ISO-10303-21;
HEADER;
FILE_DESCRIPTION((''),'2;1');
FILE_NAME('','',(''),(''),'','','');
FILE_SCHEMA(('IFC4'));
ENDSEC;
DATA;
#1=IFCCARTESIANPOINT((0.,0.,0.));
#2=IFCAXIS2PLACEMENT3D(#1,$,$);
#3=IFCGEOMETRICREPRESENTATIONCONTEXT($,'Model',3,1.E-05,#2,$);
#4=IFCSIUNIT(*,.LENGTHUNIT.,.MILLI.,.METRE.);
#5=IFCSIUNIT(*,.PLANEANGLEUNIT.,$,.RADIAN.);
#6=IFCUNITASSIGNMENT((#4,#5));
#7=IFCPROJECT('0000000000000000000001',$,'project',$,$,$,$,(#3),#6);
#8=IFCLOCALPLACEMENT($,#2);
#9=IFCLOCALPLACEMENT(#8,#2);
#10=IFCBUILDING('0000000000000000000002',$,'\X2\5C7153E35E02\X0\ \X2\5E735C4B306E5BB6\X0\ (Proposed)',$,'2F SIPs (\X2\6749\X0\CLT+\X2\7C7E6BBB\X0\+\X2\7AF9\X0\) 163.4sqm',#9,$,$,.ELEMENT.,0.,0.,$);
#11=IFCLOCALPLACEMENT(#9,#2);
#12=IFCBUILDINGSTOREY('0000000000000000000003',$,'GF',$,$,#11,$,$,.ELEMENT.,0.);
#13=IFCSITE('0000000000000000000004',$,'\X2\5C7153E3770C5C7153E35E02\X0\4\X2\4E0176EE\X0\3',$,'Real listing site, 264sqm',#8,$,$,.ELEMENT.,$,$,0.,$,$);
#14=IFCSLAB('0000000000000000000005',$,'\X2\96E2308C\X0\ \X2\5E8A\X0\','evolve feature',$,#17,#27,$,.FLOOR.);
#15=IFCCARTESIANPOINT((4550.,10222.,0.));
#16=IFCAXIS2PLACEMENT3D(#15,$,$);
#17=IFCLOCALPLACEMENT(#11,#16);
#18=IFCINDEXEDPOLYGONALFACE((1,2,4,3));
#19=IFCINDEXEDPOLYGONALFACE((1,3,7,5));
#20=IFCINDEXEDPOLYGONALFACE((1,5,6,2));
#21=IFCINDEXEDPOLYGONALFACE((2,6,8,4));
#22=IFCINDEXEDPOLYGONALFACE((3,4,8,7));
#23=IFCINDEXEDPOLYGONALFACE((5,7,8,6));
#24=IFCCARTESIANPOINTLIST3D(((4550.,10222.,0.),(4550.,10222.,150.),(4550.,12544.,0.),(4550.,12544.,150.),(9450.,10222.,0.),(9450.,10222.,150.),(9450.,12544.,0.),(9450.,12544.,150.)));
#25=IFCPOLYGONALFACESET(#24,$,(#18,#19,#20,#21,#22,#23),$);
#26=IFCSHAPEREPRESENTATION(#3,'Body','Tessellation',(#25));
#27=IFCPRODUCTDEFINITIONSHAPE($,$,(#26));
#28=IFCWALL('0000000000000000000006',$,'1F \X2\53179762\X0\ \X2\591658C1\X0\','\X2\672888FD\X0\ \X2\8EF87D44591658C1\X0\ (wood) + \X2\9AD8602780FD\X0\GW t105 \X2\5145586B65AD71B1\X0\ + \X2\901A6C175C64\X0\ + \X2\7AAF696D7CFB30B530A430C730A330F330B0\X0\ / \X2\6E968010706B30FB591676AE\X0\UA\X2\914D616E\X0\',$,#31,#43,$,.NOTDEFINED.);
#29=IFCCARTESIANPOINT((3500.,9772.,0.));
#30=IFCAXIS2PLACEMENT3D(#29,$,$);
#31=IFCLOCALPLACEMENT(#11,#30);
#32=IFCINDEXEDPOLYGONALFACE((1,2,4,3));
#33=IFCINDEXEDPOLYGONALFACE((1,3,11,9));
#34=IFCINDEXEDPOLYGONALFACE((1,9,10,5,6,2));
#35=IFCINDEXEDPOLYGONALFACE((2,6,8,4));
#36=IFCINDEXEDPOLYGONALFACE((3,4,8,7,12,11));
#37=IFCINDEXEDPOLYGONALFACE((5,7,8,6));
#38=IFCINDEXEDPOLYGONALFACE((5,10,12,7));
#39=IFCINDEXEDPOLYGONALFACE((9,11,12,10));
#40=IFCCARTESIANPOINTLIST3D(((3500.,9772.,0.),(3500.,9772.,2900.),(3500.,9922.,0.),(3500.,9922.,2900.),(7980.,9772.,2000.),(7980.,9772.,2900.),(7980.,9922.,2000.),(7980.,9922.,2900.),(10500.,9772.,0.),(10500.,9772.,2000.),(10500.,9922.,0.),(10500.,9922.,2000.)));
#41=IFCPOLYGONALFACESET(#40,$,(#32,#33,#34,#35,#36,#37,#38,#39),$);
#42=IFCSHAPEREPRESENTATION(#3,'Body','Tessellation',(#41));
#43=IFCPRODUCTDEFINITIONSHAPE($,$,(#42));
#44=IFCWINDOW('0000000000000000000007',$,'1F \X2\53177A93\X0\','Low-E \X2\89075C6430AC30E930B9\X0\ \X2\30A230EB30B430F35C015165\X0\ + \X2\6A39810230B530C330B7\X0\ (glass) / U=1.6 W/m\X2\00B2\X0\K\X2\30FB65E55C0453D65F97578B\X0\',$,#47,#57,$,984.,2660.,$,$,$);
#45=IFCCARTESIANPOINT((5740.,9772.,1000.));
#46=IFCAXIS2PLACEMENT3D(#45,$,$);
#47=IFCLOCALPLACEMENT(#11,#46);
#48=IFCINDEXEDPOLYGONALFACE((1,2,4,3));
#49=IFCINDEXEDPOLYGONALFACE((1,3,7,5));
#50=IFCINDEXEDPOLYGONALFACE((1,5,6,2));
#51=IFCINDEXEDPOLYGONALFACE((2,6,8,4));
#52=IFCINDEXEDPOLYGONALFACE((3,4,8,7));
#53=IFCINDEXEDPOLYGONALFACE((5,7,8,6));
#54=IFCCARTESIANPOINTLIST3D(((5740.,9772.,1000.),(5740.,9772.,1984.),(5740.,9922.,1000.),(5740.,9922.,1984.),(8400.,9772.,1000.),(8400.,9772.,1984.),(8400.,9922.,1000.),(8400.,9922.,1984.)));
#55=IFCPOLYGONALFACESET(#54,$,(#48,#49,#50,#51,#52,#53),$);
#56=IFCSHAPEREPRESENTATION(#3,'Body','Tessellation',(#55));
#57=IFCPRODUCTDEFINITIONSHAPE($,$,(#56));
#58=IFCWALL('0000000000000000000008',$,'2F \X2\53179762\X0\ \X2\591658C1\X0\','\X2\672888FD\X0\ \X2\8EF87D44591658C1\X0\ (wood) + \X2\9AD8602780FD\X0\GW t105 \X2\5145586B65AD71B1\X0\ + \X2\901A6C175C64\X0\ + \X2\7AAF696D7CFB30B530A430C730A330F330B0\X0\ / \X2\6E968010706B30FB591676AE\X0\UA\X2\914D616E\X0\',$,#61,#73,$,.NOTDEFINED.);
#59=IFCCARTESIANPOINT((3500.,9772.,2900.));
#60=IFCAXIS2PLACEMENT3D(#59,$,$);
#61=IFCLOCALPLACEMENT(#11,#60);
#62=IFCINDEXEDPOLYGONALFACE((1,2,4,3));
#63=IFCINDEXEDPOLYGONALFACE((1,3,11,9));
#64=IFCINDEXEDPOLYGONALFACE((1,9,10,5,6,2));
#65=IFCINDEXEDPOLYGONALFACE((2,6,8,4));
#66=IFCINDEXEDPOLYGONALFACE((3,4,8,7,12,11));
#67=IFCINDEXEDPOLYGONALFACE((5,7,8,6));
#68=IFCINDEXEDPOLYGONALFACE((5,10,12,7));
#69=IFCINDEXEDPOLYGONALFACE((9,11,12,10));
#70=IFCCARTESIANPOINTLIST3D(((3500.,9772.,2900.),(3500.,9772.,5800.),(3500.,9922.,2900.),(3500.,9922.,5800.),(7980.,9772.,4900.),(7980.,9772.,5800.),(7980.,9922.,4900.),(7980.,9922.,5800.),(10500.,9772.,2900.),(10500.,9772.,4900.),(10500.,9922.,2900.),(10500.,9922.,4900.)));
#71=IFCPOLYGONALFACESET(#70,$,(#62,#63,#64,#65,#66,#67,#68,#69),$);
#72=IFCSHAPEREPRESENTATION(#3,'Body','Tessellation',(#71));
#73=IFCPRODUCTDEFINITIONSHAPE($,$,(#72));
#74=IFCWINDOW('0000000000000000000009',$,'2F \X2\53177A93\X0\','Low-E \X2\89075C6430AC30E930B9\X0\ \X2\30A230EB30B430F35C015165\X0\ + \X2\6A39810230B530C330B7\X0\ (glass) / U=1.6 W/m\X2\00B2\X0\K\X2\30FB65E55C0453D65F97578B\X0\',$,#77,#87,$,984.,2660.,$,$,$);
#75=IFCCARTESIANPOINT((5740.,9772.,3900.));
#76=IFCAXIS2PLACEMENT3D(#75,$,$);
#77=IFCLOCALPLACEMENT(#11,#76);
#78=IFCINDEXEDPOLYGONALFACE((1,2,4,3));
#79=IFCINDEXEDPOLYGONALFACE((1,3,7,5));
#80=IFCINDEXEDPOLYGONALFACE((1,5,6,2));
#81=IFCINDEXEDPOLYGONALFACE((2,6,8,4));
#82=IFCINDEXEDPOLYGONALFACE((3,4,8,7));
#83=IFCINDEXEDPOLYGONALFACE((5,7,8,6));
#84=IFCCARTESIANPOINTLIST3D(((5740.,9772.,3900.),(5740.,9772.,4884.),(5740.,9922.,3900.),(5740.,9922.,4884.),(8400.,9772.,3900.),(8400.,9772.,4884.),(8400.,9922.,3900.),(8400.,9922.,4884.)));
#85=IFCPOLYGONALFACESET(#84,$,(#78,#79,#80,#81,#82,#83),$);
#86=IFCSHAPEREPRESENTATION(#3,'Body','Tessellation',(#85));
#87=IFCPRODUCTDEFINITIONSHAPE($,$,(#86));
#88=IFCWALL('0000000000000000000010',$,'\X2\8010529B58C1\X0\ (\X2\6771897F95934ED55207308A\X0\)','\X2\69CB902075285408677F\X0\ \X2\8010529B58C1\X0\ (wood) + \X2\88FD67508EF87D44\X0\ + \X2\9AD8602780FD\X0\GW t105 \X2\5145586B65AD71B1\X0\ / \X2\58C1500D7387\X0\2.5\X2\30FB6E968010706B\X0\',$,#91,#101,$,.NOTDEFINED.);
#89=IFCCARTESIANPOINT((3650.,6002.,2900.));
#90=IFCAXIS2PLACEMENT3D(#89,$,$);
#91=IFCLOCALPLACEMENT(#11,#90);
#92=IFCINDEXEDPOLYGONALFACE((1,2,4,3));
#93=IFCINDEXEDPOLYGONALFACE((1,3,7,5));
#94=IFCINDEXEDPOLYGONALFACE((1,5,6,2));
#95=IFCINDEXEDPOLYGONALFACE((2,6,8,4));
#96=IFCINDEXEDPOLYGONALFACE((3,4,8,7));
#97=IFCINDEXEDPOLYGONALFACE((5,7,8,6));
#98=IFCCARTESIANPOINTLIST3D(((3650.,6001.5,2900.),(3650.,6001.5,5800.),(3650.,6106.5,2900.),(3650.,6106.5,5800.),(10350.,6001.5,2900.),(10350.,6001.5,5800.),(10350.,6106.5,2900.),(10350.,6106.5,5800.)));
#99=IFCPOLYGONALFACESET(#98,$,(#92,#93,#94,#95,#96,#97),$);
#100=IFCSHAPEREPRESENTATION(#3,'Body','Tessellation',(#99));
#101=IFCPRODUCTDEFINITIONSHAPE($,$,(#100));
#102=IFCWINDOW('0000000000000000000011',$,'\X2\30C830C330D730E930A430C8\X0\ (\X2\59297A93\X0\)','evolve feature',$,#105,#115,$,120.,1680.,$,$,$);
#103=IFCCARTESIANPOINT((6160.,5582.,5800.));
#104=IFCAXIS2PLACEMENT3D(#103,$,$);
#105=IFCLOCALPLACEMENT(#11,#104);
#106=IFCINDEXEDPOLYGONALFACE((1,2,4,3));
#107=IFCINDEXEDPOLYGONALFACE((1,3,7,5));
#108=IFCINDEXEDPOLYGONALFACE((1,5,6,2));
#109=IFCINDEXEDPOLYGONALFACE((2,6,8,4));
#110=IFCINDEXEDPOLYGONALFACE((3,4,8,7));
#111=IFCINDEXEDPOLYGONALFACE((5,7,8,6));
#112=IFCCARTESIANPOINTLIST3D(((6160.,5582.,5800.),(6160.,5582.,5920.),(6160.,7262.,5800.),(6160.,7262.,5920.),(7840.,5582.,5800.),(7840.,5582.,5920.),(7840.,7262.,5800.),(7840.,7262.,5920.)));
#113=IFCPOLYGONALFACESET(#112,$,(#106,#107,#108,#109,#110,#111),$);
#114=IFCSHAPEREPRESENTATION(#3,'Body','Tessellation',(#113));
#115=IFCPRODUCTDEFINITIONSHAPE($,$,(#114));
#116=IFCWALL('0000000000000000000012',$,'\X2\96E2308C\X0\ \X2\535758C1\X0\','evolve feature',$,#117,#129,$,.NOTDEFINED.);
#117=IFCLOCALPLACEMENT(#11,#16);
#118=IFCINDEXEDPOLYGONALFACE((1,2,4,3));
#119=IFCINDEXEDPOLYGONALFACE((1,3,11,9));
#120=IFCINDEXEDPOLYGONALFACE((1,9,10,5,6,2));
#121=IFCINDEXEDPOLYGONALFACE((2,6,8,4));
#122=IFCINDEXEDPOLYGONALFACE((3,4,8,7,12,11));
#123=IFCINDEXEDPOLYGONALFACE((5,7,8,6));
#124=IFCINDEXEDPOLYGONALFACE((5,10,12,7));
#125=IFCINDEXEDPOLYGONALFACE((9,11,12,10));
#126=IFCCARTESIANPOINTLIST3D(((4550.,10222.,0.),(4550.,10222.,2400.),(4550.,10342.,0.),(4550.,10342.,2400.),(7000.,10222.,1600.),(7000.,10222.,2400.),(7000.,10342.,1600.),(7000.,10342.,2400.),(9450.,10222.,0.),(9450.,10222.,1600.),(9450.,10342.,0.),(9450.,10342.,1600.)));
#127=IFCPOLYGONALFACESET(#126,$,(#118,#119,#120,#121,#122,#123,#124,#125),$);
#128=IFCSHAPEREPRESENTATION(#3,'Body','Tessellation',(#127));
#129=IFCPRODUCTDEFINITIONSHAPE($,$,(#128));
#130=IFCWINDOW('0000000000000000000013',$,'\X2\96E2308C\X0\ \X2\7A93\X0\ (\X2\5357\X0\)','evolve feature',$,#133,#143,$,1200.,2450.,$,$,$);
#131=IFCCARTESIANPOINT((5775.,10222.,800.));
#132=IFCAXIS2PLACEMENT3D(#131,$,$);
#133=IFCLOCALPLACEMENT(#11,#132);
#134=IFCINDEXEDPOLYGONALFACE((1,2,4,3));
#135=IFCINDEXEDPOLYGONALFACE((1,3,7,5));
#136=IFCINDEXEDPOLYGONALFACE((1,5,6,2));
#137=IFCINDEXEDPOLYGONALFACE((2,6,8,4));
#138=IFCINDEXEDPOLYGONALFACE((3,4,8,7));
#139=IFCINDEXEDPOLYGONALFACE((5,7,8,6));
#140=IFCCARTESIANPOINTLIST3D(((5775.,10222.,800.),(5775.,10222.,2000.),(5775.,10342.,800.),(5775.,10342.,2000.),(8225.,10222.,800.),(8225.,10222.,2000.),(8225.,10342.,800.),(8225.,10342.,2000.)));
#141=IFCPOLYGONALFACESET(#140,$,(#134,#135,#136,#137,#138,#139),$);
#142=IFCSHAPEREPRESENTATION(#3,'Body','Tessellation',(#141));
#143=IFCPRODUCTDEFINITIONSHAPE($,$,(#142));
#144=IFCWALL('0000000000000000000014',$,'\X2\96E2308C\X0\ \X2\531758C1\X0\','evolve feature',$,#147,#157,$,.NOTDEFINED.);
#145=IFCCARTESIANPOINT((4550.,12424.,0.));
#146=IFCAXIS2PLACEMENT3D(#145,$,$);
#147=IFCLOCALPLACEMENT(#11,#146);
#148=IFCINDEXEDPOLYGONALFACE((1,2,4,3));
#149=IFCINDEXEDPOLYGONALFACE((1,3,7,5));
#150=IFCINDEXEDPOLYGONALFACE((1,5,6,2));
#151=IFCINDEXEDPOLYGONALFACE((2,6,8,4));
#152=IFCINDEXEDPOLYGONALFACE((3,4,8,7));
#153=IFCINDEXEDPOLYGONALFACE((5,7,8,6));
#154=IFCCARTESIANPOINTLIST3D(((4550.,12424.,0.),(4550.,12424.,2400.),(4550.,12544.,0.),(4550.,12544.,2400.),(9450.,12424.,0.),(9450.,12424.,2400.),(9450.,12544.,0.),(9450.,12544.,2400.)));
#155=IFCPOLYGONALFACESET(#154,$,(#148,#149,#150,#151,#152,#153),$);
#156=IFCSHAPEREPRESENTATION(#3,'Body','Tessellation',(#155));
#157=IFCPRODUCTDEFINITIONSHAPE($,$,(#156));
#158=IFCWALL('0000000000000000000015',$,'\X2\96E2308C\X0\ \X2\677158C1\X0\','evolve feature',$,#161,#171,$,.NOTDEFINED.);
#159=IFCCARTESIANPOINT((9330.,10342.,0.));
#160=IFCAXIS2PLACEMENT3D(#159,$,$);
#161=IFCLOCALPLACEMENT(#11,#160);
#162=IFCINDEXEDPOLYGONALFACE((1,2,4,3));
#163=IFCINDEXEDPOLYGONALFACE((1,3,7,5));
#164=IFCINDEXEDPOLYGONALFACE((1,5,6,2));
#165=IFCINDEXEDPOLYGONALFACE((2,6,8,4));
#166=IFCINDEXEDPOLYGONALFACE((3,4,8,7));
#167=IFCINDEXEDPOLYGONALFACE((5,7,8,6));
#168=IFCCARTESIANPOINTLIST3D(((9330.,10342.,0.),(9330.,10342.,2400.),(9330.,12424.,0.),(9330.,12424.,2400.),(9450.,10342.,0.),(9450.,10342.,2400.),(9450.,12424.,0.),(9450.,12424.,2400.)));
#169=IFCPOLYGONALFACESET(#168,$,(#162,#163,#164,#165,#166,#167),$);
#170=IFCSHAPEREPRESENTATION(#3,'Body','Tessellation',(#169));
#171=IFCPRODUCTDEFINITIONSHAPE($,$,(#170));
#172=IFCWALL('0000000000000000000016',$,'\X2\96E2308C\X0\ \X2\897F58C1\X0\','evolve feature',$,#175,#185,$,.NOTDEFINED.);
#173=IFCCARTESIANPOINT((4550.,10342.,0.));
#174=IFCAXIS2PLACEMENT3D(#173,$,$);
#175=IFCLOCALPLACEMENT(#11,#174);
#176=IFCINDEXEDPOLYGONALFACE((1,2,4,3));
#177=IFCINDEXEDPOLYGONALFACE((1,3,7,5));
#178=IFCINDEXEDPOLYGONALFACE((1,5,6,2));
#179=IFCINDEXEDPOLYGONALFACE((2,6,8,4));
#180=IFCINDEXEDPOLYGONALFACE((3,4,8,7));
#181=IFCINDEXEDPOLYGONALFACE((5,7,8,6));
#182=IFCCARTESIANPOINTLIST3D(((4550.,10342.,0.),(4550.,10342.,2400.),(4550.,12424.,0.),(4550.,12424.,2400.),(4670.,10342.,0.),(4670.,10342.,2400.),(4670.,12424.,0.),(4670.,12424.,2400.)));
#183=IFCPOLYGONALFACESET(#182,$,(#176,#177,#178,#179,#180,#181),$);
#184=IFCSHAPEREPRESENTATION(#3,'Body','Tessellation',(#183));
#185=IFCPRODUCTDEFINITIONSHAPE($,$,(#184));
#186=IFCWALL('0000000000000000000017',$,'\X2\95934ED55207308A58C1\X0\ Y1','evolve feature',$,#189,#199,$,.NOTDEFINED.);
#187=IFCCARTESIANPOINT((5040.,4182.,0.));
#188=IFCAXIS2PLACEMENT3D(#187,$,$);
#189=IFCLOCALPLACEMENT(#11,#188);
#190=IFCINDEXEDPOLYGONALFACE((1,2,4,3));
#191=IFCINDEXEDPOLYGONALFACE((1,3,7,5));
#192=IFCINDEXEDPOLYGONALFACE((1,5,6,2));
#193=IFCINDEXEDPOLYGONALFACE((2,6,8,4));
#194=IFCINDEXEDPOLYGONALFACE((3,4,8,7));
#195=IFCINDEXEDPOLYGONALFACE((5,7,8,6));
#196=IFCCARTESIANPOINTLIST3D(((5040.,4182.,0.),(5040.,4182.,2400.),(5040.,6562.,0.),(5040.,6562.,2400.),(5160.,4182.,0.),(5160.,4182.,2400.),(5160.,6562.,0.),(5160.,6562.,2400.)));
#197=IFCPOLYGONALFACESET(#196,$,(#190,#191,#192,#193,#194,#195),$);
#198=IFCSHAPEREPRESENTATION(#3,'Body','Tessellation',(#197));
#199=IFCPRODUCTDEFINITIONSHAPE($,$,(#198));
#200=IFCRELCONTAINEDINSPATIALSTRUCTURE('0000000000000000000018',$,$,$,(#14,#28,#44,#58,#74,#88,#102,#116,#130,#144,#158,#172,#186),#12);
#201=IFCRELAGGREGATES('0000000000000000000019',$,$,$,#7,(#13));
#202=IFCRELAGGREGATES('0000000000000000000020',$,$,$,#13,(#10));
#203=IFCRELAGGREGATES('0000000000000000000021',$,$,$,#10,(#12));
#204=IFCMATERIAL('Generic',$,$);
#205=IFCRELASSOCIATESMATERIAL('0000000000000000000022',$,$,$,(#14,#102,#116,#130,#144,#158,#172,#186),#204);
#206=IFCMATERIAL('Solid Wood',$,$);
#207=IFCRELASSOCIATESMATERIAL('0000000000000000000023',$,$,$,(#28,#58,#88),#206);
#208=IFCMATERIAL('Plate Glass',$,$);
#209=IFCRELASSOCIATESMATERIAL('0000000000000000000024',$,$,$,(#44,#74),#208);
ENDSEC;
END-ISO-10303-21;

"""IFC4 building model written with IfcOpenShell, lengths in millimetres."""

from ifc_helpers import new_model, si_unit, frame, frame_2d, origin, place, context, project, spatial, rectangle, extrude, material, element, fill, save


model = new_model("IFC4")

# Units and contexts
model_context = context("Model", 3, precision=1e-05, world=origin())
ifc_project = project(units=[si_unit("LENGTHUNIT", "METRE", prefix="MILLI"), si_unit("PLANEANGLEUNIT", "RADIAN")], contexts=[model_context])

# Site, building, storey
site_placement = place(None, origin())
site = spatial("IfcSite", under=ifc_project, at=site_placement, Name="山口県山口市4丁目3", ObjectType="Real listing site, 264sqm", CompositionType="ELEMENT", RefElevation=0.0)
building_placement = place(site_placement, origin())
building = spatial("IfcBuilding", under=site, at=building_placement, Name="山口市 平屋の家 (Proposed)", ObjectType="2F SIPs (杉CLT+籾殻+竹) 163.4sqm", CompositionType="ELEMENT", ElevationOfRefHeight=0.0, ElevationOfTerrain=0.0)
storey_placement = place(building_placement, origin())
storey = spatial("IfcBuildingStorey", under=building, at=storey_placement, Name="GF", CompositionType="ELEMENT", Elevation=0.0)

# Slab
ifc_material_1 = material(Name="Generic")
slab_placement = place(storey_placement, frame((4550.0, 10222.0, 0.0)))
element("IfcSlab", 1, at=slab_placement, inside=storey, material=ifc_material_1, Name="離れ 床", Description="evolve feature", PredefinedType="FLOOR", context=model_context, shape_type="SweptSolid", body=[
    extrude(rectangle(XDim=4900.0, YDim=2322.0, at=frame_2d((2450.0, 1161.0))), frame((4550.0, 10222.0, 0.0)), (0.0, 0.0, 1.0), 150.0),
])

# Wall, opening, window
ifc_material_2 = material(Name="Solid Wood")
wall_1_placement = place(storey_placement, frame((3500.0, 9772.0, 0.0)))
wall_1 = element("IfcWall", 2, at=wall_1_placement, inside=storey, material=ifc_material_2, Name="1F 北面 外壁", Description="木製 軸組外壁 (wood) + 高性能GW t105 充填断熱 + 通気層 + 窯業系サイディング / 準耐火・外皮UA配慮", PredefinedType="NOTDEFINED", context=model_context, shape_type="SweptSolid", body=[
    extrude(rectangle(XDim=7000.0, YDim=150.0, at=frame_2d((3500.0, 75.0))), frame((3500.0, 9772.0, 0.0)), (0.0, 0.0, 1.0), 2900.0),
])
opening_1_placement = place(storey_placement, frame((5740.0, 9772.0, 1000.0)))
opening_1 = element("IfcOpeningElement", 3, at=opening_1_placement, cuts=wall_1, PredefinedType="NOTDEFINED", context=model_context, shape_type="SweptSolid", body=[
    extrude(rectangle(XDim=2660.0, YDim=150.0, at=frame_2d((1330.0, 75.0))), frame((5740.0, 9772.0, 1000.0)), (0.0, 0.0, 1.0), 984.0),
])
ifc_material_3 = material(Name="Plate Glass")
window_1_placement = place(storey_placement, frame((5740.0, 9772.0, 1000.0)))
window_1 = element("IfcWindow", 4, at=window_1_placement, inside=storey, material=ifc_material_3, Name="1F 北窓", Description="Low-E 複層ガラス アルゴン封入 + 樹脂サッシ (glass) / U=1.6 W/m²K・日射取得型", OverallHeight=984.0, OverallWidth=2660.0, context=model_context, shape_type="SweptSolid", body=[
    extrude(rectangle(XDim=2660.0, YDim=150.0, at=frame_2d((1330.0, 75.0))), frame((5740.0, 9772.0, 1000.0)), (0.0, 0.0, 1.0), 984.0),
])
fill(opening_1, window_1)

# Wall, opening, window
wall_2_placement = place(storey_placement, frame((3500.0, 9772.0, 2900.0)))
wall_2 = element("IfcWall", 5, at=wall_2_placement, inside=storey, material=ifc_material_2, Name="2F 北面 外壁", Description="木製 軸組外壁 (wood) + 高性能GW t105 充填断熱 + 通気層 + 窯業系サイディング / 準耐火・外皮UA配慮", PredefinedType="NOTDEFINED", context=model_context, shape_type="SweptSolid", body=[
    extrude(rectangle(XDim=7000.0, YDim=150.0, at=frame_2d((3500.0, 75.0))), frame((3500.0, 9772.0, 2900.0)), (0.0, 0.0, 1.0), 2900.0),
])
opening_2_placement = place(storey_placement, frame((5740.0, 9772.0, 3900.0)))
opening_2 = element("IfcOpeningElement", 6, at=opening_2_placement, cuts=wall_2, PredefinedType="NOTDEFINED", context=model_context, shape_type="SweptSolid", body=[
    extrude(rectangle(XDim=2660.0, YDim=150.0, at=frame_2d((1330.0, 75.0))), frame((5740.0, 9772.0, 3900.0)), (0.0, 0.0, 1.0), 984.0),
])
window_2_placement = place(storey_placement, frame((5740.0, 9772.0, 3900.0)))
window_2 = element("IfcWindow", 7, at=window_2_placement, inside=storey, material=ifc_material_3, Name="2F 北窓", Description="Low-E 複層ガラス アルゴン封入 + 樹脂サッシ (glass) / U=1.6 W/m²K・日射取得型", OverallHeight=984.0, OverallWidth=2660.0, context=model_context, shape_type="SweptSolid", body=[
    extrude(rectangle(XDim=2660.0, YDim=150.0, at=frame_2d((1330.0, 75.0))), frame((5740.0, 9772.0, 3900.0)), (0.0, 0.0, 1.0), 984.0),
])
fill(opening_2, window_2)

# Wall
wall_3_placement = place(storey_placement, frame((3650.0, 6002.0, 2900.0)))
element("IfcWall", 8, at=wall_3_placement, inside=storey, material=ifc_material_2, Name="耐力壁 (東西間仕切り)", Description="構造用合板 耐力壁 (wood) + 製材軸組 + 高性能GW t105 充填断熱 / 壁倍率2.5・準耐火", PredefinedType="NOTDEFINED", context=model_context, shape_type="SweptSolid", body=[
    extrude(rectangle(XDim=6700.0, YDim=105.0, at=frame_2d((3350.0, 52.0))), frame((3650.0, 6002.0, 2900.0)), (0.0, 0.0, 1.0), 2900.0),
])

# Window
window_3_placement = place(storey_placement, frame((6160.0, 5582.0, 5800.0)))
element("IfcWindow", 9, at=window_3_placement, inside=storey, material=ifc_material_1, Name="トップライト (天窓)", Description="evolve feature", OverallHeight=120.0, OverallWidth=1680.0, context=model_context, shape_type="SweptSolid", body=[
    extrude(rectangle(XDim=1680.0, YDim=1680.0, at=frame_2d((840.0, 840.0))), frame((6160.0, 5582.0, 5800.0)), (0.0, 0.0, 1.0), 120.0),
])

# Wall, opening, window
wall_4_placement = place(storey_placement, frame((4550.0, 10222.0, 0.0)))
wall_4 = element("IfcWall", 10, at=wall_4_placement, inside=storey, material=ifc_material_1, Name="離れ 南壁", Description="evolve feature", PredefinedType="NOTDEFINED", context=model_context, shape_type="SweptSolid", body=[
    extrude(rectangle(XDim=4900.0, YDim=120.0, at=frame_2d((2450.0, 60.0))), frame((4550.0, 10222.0, 0.0)), (0.0, 0.0, 1.0), 2400.0),
])
opening_3_placement = place(storey_placement, frame((5775.0, 10222.0, 800.0)))
opening_3 = element("IfcOpeningElement", 11, at=opening_3_placement, cuts=wall_4, PredefinedType="NOTDEFINED", context=model_context, shape_type="SweptSolid", body=[
    extrude(rectangle(XDim=2450.0, YDim=120.0, at=frame_2d((1225.0, 60.0))), frame((5775.0, 10222.0, 800.0)), (0.0, 0.0, 1.0), 1200.0),
])
window_4_placement = place(storey_placement, frame((5775.0, 10222.0, 800.0)))
window_4 = element("IfcWindow", 12, at=window_4_placement, inside=storey, material=ifc_material_1, Name="離れ 窓 (南)", Description="evolve feature", OverallHeight=1200.0, OverallWidth=2450.0, context=model_context, shape_type="SweptSolid", body=[
    extrude(rectangle(XDim=2450.0, YDim=120.0, at=frame_2d((1225.0, 60.0))), frame((5775.0, 10222.0, 800.0)), (0.0, 0.0, 1.0), 1200.0),
])
fill(opening_3, window_4)

# Walls
wall_5_placement = place(storey_placement, frame((4550.0, 12424.0, 0.0)))
element("IfcWall", 13, at=wall_5_placement, inside=storey, material=ifc_material_1, Name="離れ 北壁", Description="evolve feature", PredefinedType="NOTDEFINED", context=model_context, shape_type="SweptSolid", body=[
    extrude(rectangle(XDim=4900.0, YDim=120.0, at=frame_2d((2450.0, 60.0))), frame((4550.0, 12424.0, 0.0)), (0.0, 0.0, 1.0), 2400.0),
])
wall_6_placement = place(storey_placement, frame((9330.0, 10342.0, 0.0)))
element("IfcWall", 14, at=wall_6_placement, inside=storey, material=ifc_material_1, Name="離れ 東壁", Description="evolve feature", PredefinedType="NOTDEFINED", context=model_context, shape_type="SweptSolid", body=[
    extrude(rectangle(XDim=120.0, YDim=2082.0, at=frame_2d((60.0, 1041.0))), frame((9330.0, 10342.0, 0.0)), (0.0, 0.0, 1.0), 2400.0),
])
wall_7_placement = place(storey_placement, frame((4550.0, 10342.0, 0.0)))
element("IfcWall", 15, at=wall_7_placement, inside=storey, material=ifc_material_1, Name="離れ 西壁", Description="evolve feature", PredefinedType="NOTDEFINED", context=model_context, shape_type="SweptSolid", body=[
    extrude(rectangle(XDim=120.0, YDim=2082.0, at=frame_2d((60.0, 1041.0))), frame((4550.0, 10342.0, 0.0)), (0.0, 0.0, 1.0), 2400.0),
])
wall_8_placement = place(storey_placement, frame((5040.0, 4182.0, 0.0)))
element("IfcWall", 16, at=wall_8_placement, inside=storey, material=ifc_material_1, Name="間仕切り壁 Y1", Description="evolve feature", PredefinedType="NOTDEFINED", context=model_context, shape_type="SweptSolid", body=[
    extrude(rectangle(XDim=120.0, YDim=2380.0, at=frame_2d((60.0, 1190.0))), frame((5040.0, 4182.0, 0.0)), (0.0, 0.0, 1.0), 2400.0),
])

save(model, "model.ifc")
